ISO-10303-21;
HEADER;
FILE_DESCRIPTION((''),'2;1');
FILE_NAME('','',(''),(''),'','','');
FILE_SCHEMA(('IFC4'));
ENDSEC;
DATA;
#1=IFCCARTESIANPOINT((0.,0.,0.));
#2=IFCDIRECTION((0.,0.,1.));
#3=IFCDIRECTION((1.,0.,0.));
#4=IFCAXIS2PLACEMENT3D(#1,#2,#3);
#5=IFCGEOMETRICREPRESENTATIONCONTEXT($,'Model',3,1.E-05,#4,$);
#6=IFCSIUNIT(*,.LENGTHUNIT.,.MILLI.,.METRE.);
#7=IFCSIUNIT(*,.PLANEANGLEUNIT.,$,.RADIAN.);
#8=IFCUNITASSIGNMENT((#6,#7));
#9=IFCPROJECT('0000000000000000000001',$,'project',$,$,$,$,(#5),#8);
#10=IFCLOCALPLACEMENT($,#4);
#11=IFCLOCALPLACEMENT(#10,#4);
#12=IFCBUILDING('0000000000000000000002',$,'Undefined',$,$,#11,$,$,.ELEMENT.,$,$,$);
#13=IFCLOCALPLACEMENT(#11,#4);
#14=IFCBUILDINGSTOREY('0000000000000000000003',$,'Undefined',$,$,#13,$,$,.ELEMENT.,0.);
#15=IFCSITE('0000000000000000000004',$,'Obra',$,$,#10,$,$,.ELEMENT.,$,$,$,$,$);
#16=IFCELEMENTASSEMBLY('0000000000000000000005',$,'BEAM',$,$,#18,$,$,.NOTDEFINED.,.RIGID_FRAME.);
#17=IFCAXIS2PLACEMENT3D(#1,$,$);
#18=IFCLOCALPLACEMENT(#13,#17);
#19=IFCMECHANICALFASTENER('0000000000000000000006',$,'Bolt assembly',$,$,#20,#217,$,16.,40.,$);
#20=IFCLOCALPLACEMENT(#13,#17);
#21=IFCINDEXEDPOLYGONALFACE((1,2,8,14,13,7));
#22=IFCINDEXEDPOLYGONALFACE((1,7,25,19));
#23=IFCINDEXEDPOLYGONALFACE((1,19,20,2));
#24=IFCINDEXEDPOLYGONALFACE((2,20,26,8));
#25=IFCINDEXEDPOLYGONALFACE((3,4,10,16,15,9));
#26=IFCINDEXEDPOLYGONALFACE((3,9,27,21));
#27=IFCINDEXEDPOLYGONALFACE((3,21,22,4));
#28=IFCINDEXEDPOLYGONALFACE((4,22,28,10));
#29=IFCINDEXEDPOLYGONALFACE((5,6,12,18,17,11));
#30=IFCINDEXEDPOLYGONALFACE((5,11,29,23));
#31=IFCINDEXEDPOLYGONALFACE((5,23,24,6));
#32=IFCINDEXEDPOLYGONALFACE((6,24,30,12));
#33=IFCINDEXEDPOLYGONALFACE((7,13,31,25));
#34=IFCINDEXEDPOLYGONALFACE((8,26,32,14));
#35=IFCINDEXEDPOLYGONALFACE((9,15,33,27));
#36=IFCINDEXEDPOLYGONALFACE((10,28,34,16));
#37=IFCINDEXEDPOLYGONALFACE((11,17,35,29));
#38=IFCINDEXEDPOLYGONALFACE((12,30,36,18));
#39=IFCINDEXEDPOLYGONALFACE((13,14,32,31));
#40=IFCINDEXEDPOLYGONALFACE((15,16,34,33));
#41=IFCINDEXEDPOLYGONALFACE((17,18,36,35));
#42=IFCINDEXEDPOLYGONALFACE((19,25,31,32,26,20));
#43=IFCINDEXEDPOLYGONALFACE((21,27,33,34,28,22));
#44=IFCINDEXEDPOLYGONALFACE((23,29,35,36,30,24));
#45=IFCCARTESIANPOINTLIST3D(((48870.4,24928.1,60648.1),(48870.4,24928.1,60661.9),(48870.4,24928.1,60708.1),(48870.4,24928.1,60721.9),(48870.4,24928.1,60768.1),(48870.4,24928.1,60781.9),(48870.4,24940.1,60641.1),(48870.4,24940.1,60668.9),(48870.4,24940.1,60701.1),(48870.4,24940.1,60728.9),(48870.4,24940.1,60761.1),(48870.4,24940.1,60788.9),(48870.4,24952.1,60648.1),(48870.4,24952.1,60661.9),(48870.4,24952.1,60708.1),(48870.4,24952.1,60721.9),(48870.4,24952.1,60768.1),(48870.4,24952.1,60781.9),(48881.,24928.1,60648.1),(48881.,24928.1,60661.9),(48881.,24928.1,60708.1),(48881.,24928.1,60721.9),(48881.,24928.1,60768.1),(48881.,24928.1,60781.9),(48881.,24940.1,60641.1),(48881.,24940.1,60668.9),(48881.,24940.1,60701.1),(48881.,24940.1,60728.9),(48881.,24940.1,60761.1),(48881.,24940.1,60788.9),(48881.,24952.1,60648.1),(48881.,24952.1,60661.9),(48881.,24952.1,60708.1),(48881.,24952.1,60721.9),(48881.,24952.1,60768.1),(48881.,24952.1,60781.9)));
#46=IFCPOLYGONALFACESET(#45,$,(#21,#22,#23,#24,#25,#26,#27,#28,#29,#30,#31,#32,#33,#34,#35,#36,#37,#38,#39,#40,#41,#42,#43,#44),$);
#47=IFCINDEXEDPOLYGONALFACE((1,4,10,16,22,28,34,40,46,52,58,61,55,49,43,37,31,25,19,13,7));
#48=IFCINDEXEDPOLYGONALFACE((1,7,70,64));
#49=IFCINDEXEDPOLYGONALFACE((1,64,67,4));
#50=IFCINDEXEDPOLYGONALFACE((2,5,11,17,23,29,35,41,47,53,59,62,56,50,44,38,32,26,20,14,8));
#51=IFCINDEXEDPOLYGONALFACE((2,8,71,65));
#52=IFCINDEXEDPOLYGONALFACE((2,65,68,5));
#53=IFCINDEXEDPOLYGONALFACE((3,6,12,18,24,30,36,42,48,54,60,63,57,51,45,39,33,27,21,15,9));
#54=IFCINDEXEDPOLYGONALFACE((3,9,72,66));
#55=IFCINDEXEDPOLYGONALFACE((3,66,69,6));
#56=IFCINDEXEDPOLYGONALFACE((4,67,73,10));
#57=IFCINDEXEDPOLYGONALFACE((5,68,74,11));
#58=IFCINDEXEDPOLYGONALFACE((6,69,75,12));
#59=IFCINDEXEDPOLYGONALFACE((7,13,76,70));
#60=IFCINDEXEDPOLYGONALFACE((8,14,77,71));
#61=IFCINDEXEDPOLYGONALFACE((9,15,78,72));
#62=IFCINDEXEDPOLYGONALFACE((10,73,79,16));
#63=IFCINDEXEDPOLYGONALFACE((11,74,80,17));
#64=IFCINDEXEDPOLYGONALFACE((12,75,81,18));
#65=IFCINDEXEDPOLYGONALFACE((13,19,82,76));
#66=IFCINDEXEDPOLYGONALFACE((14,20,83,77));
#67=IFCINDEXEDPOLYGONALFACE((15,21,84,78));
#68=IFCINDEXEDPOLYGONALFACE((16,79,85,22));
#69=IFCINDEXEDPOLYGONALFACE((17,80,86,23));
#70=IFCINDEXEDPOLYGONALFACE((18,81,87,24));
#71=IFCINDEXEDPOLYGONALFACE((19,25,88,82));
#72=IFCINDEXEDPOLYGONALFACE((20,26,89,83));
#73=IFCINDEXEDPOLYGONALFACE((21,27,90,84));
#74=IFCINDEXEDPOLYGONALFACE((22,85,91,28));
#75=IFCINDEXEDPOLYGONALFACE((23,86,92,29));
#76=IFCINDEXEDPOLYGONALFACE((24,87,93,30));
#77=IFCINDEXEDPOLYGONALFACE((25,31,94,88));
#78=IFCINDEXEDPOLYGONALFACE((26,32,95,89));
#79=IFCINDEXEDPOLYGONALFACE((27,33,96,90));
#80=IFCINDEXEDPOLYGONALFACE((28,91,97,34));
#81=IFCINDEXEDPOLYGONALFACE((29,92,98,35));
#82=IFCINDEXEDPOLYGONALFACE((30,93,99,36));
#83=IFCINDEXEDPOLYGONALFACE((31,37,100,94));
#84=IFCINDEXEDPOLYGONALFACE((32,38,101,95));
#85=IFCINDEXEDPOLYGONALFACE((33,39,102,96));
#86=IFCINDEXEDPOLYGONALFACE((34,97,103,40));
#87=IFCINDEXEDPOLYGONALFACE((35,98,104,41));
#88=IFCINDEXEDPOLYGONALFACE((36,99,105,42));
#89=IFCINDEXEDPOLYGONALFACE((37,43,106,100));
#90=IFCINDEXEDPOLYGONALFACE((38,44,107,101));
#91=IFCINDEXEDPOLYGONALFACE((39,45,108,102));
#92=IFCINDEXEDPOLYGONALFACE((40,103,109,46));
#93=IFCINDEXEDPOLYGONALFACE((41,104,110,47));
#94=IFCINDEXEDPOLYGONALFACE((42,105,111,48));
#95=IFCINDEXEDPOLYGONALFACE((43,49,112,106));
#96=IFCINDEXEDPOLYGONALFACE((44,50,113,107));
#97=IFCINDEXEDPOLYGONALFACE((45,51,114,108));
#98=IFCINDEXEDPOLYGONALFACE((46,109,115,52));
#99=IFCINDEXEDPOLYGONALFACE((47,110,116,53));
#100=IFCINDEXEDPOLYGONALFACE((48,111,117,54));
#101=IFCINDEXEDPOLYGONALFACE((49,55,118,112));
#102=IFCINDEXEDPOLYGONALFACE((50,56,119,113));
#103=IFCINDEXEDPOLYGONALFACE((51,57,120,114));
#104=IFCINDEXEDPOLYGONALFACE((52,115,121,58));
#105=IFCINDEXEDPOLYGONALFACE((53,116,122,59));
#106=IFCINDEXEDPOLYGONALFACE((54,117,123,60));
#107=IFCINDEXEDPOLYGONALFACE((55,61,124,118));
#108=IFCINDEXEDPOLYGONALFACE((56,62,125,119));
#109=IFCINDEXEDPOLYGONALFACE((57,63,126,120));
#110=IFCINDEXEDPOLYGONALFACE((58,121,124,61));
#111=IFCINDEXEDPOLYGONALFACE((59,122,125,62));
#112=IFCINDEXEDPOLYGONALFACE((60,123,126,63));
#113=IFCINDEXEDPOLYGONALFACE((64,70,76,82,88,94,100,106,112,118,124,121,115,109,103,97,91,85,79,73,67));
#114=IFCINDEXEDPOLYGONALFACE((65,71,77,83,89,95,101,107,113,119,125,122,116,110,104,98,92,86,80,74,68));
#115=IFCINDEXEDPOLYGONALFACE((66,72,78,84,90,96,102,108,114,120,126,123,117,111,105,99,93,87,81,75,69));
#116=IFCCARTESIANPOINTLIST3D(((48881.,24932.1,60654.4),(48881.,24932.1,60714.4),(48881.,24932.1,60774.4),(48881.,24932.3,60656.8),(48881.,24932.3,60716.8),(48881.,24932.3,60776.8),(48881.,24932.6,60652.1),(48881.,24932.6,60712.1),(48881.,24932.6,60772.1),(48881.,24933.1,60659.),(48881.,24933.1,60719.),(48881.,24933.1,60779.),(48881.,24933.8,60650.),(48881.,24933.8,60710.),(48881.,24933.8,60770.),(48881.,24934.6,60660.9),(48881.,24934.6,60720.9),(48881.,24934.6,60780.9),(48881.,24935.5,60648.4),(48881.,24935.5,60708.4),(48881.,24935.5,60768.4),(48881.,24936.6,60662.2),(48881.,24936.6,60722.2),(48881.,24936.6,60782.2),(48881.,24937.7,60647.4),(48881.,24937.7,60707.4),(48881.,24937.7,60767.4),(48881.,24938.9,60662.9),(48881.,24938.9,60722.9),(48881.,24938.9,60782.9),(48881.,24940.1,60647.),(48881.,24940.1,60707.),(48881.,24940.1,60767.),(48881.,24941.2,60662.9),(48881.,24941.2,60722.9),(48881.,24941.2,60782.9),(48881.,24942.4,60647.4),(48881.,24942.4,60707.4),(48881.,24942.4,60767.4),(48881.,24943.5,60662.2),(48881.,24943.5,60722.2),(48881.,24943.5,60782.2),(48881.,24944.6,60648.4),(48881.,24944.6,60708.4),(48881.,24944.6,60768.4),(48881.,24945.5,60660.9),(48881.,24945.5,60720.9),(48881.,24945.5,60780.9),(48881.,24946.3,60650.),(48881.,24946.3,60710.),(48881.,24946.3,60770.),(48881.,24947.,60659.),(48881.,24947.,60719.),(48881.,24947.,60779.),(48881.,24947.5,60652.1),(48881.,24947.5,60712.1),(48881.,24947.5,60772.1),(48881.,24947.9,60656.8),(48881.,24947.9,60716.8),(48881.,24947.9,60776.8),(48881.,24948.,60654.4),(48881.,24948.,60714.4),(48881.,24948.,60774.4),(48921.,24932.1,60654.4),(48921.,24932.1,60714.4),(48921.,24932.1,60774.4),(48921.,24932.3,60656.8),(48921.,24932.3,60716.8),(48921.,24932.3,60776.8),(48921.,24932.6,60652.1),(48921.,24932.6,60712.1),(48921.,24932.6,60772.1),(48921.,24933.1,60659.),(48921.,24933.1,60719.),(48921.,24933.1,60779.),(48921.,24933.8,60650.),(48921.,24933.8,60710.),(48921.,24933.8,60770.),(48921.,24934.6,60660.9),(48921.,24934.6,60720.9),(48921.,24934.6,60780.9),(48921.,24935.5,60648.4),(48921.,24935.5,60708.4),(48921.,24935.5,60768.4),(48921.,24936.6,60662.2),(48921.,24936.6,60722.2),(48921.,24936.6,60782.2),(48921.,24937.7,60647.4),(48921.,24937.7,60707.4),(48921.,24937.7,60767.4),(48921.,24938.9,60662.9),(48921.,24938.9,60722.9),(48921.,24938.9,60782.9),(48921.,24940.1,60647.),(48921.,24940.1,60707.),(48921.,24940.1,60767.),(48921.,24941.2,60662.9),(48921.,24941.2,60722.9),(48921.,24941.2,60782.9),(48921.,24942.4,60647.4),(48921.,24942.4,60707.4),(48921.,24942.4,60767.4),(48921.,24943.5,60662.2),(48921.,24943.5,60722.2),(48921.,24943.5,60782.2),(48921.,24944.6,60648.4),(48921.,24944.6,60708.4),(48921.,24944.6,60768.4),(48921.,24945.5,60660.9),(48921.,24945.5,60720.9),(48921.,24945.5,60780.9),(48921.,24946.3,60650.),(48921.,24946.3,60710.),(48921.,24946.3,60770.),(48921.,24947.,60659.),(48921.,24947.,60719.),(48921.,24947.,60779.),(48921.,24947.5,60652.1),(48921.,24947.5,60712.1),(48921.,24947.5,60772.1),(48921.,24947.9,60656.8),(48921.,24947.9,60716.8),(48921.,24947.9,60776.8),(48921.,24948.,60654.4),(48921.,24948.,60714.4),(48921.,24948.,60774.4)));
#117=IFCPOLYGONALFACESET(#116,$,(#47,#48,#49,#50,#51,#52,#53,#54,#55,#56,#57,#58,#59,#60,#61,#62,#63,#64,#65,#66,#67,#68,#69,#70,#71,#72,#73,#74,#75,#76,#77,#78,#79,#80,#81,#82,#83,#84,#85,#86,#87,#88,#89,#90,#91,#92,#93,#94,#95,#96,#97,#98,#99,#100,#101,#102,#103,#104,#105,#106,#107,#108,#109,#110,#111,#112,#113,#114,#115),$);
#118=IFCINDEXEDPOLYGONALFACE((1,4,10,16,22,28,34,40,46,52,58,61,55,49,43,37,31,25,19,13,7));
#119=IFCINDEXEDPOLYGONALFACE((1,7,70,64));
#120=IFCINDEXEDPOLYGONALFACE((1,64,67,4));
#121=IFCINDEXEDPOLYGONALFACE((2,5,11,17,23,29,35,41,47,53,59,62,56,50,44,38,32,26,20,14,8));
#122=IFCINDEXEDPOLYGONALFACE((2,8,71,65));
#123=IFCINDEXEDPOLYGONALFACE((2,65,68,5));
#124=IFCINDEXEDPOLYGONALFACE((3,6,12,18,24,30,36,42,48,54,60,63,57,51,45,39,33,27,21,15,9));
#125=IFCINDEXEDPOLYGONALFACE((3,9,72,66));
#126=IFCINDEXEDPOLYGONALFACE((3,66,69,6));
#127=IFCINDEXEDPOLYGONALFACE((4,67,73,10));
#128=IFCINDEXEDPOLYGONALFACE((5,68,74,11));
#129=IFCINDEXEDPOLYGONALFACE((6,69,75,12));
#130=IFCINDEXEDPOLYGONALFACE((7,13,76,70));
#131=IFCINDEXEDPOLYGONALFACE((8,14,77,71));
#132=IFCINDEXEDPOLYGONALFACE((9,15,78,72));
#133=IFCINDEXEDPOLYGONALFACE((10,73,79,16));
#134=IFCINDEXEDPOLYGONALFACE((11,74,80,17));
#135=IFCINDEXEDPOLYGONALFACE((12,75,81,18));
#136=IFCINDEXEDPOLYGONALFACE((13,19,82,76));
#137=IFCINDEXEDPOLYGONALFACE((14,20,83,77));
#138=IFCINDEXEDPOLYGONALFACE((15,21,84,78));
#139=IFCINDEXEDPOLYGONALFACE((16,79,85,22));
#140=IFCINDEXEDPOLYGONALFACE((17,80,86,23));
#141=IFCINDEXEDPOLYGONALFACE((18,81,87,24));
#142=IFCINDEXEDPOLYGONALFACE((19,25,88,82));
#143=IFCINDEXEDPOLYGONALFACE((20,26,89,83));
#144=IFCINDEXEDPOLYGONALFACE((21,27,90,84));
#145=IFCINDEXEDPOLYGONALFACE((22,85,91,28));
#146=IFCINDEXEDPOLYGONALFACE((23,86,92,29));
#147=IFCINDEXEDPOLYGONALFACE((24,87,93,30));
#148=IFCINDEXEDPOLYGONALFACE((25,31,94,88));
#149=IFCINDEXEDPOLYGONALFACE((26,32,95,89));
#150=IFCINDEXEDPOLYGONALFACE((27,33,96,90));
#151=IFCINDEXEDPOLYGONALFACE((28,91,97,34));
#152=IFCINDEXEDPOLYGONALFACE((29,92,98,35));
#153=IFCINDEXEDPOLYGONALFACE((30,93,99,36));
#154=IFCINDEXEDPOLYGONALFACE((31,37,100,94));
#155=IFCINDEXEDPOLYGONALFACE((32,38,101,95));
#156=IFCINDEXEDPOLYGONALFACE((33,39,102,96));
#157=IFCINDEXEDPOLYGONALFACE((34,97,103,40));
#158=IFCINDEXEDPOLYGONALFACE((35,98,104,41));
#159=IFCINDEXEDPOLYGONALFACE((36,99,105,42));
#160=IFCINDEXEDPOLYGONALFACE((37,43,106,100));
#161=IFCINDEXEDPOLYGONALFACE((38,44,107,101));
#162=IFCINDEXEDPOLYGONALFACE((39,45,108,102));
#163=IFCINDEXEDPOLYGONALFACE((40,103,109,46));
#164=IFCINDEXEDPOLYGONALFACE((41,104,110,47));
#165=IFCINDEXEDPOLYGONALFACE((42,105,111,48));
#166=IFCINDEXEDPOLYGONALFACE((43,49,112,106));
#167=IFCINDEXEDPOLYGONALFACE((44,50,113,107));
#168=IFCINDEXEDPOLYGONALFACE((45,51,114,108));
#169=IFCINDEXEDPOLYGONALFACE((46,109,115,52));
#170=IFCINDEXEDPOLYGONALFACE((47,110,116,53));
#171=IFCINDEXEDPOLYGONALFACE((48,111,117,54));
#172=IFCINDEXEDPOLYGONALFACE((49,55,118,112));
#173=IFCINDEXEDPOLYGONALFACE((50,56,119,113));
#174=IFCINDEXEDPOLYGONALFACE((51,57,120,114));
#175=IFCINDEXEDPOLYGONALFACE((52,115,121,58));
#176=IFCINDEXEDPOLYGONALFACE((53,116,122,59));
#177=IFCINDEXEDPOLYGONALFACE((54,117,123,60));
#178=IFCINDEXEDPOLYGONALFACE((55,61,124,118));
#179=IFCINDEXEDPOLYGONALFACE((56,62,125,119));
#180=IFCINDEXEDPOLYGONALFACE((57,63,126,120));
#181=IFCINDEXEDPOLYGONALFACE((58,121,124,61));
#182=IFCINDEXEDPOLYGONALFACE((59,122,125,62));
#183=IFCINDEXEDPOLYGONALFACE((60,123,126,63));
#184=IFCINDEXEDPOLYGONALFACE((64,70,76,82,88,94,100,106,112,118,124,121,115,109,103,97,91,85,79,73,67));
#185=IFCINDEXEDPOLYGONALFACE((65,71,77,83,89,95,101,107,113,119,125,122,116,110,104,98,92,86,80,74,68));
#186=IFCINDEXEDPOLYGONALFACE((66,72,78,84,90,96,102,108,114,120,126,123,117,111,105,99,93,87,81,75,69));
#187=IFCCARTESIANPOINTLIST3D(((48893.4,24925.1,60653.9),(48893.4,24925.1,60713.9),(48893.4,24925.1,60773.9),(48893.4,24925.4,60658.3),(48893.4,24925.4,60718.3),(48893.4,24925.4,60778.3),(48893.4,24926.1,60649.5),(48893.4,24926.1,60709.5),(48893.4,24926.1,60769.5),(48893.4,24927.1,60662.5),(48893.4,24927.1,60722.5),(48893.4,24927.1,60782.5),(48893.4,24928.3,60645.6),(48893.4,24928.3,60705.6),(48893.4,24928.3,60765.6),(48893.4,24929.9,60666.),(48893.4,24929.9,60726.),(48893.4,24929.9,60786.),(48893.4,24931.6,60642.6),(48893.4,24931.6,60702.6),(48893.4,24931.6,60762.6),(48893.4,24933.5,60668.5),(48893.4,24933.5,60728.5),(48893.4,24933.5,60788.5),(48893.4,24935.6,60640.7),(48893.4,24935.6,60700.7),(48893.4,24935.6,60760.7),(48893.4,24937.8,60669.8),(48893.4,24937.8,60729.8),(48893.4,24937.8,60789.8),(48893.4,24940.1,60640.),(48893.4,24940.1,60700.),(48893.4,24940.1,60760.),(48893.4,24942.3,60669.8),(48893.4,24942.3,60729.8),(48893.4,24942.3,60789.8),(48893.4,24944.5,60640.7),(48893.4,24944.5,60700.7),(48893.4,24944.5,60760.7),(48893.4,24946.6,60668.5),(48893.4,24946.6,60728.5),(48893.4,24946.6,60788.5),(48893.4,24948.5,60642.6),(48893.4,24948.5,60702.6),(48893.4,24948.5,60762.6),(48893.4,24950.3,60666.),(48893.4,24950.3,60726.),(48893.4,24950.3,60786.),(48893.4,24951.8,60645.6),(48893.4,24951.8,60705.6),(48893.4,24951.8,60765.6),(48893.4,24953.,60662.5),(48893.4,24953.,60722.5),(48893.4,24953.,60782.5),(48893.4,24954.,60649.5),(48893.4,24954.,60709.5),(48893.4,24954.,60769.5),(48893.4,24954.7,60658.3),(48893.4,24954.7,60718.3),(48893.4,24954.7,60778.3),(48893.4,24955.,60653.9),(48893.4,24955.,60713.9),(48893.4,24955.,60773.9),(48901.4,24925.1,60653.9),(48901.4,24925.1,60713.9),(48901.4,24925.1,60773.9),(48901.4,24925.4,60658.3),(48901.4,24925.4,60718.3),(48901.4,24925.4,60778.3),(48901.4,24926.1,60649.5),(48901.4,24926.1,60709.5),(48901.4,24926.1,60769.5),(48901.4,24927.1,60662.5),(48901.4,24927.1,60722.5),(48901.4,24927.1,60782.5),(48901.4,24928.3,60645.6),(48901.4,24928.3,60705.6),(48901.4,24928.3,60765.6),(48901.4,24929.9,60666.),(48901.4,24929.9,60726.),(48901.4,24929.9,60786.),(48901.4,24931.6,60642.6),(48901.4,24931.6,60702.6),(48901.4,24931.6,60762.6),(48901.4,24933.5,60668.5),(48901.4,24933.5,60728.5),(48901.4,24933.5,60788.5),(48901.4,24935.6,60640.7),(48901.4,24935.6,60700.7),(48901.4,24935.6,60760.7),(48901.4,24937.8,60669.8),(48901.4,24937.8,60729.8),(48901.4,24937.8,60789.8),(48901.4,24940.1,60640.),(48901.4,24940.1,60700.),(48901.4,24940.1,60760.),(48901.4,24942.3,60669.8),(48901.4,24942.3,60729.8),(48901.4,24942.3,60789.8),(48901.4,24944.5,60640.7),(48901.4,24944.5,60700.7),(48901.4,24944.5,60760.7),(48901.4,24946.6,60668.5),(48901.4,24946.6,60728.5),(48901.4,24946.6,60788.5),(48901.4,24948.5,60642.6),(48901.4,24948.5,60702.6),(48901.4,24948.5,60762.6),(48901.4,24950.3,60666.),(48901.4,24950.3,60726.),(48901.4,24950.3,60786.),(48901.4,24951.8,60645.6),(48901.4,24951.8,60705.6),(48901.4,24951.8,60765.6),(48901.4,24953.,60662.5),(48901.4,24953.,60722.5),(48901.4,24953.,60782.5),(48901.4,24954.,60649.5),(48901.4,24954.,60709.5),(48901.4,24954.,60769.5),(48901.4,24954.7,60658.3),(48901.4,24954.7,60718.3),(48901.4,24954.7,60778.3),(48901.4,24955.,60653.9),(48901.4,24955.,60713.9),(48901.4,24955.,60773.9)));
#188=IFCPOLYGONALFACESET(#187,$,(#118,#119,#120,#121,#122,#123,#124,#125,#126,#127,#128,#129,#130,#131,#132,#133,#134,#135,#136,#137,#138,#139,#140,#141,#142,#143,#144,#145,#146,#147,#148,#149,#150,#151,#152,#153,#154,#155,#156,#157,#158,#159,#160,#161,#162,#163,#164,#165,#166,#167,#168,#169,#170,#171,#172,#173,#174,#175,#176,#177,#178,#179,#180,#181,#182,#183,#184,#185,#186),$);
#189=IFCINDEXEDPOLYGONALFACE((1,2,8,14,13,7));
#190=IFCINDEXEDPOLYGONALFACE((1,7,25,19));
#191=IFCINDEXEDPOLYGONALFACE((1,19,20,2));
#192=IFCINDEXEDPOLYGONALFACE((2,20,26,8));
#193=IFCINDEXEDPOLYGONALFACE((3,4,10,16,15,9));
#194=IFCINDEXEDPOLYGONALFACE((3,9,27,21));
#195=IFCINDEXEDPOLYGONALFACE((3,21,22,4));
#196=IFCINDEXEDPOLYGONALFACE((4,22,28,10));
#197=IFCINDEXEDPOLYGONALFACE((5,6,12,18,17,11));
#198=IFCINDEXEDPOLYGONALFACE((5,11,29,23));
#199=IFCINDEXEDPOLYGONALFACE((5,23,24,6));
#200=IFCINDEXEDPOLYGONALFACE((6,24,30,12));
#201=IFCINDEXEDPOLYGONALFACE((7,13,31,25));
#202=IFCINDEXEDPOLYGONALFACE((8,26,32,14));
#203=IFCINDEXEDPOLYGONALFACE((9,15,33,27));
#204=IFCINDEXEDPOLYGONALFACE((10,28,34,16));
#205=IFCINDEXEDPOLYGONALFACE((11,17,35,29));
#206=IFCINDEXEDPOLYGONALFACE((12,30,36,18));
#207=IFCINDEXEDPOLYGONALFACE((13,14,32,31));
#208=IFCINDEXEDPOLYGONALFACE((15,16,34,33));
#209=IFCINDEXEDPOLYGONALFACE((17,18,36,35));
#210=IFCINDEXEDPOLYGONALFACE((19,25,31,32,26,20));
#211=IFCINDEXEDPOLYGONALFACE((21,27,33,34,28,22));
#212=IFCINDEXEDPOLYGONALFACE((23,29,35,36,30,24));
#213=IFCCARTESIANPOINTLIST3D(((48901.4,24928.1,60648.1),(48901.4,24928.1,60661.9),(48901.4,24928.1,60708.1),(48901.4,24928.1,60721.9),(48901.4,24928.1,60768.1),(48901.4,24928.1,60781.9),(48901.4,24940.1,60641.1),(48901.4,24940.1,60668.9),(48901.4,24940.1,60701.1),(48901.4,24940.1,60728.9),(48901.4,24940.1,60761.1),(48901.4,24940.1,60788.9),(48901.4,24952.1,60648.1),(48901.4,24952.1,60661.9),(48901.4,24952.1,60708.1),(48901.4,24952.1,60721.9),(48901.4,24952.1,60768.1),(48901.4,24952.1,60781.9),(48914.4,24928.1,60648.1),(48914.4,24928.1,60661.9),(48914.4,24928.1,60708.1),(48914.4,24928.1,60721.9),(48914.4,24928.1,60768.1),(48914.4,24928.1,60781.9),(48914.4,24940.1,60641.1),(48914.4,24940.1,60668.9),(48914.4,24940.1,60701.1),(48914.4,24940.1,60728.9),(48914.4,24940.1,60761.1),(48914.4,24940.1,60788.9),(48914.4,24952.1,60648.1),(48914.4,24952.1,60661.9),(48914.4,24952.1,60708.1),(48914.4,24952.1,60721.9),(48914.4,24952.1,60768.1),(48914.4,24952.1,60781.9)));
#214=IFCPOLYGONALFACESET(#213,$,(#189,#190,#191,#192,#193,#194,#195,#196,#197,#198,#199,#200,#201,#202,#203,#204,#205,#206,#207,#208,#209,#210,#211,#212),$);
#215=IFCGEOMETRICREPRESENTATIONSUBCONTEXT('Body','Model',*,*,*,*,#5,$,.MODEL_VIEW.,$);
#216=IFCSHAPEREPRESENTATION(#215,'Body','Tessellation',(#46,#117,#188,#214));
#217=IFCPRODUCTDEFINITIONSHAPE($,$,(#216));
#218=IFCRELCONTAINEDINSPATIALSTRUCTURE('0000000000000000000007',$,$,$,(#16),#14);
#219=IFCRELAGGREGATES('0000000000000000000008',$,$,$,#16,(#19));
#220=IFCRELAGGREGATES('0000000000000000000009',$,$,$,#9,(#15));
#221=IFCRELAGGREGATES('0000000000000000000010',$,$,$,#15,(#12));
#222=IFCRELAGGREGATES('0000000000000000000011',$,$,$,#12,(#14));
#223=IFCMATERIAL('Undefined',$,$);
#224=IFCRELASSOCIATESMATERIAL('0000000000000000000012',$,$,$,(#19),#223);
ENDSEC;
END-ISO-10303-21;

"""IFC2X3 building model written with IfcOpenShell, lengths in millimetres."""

from ifc_helpers import new_model, si_unit, frame, origin_with_axes, origin_2d_with_axis, place, context, subcontext, project, spatial, polyline, circle, outline, extrude, source, transform, mapped, material, element, aggregate, save


model = new_model("IFC2X3")

# Units and contexts
model_context = context("Model", 3, precision=1e-05, world=origin_with_axes())
body_context = subcontext(model_context, "Body", "Model", "MODEL_VIEW")
ifc_project = project(units=[si_unit("LENGTHUNIT", "METRE", prefix="MILLI"), si_unit("PLANEANGLEUNIT", "RADIAN")], contexts=[model_context])

# Site, building, storey
site_placement = place(None, origin_with_axes())
site = spatial("IfcSite", under=ifc_project, at=site_placement, Name="Obra", CompositionType="ELEMENT")
building_placement = place(site_placement, origin_with_axes())
building = spatial("IfcBuilding", under=site, at=building_placement, Name="Undefined", CompositionType="ELEMENT")
storey_placement = place(building_placement, origin_with_axes())
storey = spatial("IfcBuildingStorey", under=building, at=storey_placement, Name="Undefined", CompositionType="ELEMENT", Elevation=0.0)

# Element assembly
ifc_material_1 = material(Name="Undefined")
assembly_1_placement = place(storey_placement, origin_with_axes())
assembly_1 = element("IfcElementAssembly", 1, at=assembly_1_placement, inside=storey, Name="BEAM", AssemblyPlace="NOTDEFINED", PredefinedType="RIGID_FRAME")

# Mechanical fastener
shared_shape_1 = source(origin_with_axes(), body_context, "Body", "SweptSolid", [
    extrude(outline(polyline([(13.9, 0.0), (6.9, 12.0), (-6.9, 12.0), (-13.9, 0.0), (-6.9, -12.0), (6.9, -12.0), (13.9, 0.0)])), frame((0.0, -19.7, 0.0), z_axis=(0.0, 1.0, 0.0), x_axis=(1.0, 0.0, 0.0)), (0.0, 0.0, 1.0), 10.6),
    extrude(circle(Radius=8.0, at=origin_2d_with_axis()), frame((0.0, -9.1, 0.0), z_axis=(0.0, 1.0, 0.0), x_axis=(1.0, 0.0, 0.0)), (0.0, 0.0, 1.0), 40.0),
    extrude(circle(Radius=15.0, at=origin_2d_with_axis()), frame((0.0, 3.3, 0.0), z_axis=(0.0, 1.0, 0.0), x_axis=(1.0, 0.0, 0.0)), (0.0, 0.0, 1.0), 8.0),
    extrude(outline(polyline([(13.9, 0.0), (6.9, 12.0), (-6.9, 12.0), (-13.9, 0.0), (-6.9, -12.0), (6.9, -12.0), (13.9, 0.0)])), frame((0.0, 11.3, 0.0), z_axis=(0.0, 1.0, 0.0), x_axis=(1.0, 0.0, 0.0)), (0.0, 0.0, 1.0), 13.0),
])
mechanical_fastener_1_placement = place(assembly_1_placement, frame((48890.1, 24990.1, 60835.0), z_axis=(0.000002, -1.0, 0.0), x_axis=(0.0, 0.0, -1.0)))
mechanical_fastener_1 = element("IfcMechanicalFastener", 2, at=mechanical_fastener_1_placement, material=ifc_material_1, Name="Bolt assembly", NominalDiameter=16.0, NominalLength=40.0, context=body_context, shape_type="MappedRepresentation", body=[
    mapped(shared_shape_1, transform((60.0, 0.0, 50.0))),
    mapped(shared_shape_1, transform((120.0, 0.0, 50.0))),
    mapped(shared_shape_1, transform((180.0, 0.0, 50.0))),
])
aggregate(assembly_1, [mechanical_fastener_1])

save(model, "model.ifc")
